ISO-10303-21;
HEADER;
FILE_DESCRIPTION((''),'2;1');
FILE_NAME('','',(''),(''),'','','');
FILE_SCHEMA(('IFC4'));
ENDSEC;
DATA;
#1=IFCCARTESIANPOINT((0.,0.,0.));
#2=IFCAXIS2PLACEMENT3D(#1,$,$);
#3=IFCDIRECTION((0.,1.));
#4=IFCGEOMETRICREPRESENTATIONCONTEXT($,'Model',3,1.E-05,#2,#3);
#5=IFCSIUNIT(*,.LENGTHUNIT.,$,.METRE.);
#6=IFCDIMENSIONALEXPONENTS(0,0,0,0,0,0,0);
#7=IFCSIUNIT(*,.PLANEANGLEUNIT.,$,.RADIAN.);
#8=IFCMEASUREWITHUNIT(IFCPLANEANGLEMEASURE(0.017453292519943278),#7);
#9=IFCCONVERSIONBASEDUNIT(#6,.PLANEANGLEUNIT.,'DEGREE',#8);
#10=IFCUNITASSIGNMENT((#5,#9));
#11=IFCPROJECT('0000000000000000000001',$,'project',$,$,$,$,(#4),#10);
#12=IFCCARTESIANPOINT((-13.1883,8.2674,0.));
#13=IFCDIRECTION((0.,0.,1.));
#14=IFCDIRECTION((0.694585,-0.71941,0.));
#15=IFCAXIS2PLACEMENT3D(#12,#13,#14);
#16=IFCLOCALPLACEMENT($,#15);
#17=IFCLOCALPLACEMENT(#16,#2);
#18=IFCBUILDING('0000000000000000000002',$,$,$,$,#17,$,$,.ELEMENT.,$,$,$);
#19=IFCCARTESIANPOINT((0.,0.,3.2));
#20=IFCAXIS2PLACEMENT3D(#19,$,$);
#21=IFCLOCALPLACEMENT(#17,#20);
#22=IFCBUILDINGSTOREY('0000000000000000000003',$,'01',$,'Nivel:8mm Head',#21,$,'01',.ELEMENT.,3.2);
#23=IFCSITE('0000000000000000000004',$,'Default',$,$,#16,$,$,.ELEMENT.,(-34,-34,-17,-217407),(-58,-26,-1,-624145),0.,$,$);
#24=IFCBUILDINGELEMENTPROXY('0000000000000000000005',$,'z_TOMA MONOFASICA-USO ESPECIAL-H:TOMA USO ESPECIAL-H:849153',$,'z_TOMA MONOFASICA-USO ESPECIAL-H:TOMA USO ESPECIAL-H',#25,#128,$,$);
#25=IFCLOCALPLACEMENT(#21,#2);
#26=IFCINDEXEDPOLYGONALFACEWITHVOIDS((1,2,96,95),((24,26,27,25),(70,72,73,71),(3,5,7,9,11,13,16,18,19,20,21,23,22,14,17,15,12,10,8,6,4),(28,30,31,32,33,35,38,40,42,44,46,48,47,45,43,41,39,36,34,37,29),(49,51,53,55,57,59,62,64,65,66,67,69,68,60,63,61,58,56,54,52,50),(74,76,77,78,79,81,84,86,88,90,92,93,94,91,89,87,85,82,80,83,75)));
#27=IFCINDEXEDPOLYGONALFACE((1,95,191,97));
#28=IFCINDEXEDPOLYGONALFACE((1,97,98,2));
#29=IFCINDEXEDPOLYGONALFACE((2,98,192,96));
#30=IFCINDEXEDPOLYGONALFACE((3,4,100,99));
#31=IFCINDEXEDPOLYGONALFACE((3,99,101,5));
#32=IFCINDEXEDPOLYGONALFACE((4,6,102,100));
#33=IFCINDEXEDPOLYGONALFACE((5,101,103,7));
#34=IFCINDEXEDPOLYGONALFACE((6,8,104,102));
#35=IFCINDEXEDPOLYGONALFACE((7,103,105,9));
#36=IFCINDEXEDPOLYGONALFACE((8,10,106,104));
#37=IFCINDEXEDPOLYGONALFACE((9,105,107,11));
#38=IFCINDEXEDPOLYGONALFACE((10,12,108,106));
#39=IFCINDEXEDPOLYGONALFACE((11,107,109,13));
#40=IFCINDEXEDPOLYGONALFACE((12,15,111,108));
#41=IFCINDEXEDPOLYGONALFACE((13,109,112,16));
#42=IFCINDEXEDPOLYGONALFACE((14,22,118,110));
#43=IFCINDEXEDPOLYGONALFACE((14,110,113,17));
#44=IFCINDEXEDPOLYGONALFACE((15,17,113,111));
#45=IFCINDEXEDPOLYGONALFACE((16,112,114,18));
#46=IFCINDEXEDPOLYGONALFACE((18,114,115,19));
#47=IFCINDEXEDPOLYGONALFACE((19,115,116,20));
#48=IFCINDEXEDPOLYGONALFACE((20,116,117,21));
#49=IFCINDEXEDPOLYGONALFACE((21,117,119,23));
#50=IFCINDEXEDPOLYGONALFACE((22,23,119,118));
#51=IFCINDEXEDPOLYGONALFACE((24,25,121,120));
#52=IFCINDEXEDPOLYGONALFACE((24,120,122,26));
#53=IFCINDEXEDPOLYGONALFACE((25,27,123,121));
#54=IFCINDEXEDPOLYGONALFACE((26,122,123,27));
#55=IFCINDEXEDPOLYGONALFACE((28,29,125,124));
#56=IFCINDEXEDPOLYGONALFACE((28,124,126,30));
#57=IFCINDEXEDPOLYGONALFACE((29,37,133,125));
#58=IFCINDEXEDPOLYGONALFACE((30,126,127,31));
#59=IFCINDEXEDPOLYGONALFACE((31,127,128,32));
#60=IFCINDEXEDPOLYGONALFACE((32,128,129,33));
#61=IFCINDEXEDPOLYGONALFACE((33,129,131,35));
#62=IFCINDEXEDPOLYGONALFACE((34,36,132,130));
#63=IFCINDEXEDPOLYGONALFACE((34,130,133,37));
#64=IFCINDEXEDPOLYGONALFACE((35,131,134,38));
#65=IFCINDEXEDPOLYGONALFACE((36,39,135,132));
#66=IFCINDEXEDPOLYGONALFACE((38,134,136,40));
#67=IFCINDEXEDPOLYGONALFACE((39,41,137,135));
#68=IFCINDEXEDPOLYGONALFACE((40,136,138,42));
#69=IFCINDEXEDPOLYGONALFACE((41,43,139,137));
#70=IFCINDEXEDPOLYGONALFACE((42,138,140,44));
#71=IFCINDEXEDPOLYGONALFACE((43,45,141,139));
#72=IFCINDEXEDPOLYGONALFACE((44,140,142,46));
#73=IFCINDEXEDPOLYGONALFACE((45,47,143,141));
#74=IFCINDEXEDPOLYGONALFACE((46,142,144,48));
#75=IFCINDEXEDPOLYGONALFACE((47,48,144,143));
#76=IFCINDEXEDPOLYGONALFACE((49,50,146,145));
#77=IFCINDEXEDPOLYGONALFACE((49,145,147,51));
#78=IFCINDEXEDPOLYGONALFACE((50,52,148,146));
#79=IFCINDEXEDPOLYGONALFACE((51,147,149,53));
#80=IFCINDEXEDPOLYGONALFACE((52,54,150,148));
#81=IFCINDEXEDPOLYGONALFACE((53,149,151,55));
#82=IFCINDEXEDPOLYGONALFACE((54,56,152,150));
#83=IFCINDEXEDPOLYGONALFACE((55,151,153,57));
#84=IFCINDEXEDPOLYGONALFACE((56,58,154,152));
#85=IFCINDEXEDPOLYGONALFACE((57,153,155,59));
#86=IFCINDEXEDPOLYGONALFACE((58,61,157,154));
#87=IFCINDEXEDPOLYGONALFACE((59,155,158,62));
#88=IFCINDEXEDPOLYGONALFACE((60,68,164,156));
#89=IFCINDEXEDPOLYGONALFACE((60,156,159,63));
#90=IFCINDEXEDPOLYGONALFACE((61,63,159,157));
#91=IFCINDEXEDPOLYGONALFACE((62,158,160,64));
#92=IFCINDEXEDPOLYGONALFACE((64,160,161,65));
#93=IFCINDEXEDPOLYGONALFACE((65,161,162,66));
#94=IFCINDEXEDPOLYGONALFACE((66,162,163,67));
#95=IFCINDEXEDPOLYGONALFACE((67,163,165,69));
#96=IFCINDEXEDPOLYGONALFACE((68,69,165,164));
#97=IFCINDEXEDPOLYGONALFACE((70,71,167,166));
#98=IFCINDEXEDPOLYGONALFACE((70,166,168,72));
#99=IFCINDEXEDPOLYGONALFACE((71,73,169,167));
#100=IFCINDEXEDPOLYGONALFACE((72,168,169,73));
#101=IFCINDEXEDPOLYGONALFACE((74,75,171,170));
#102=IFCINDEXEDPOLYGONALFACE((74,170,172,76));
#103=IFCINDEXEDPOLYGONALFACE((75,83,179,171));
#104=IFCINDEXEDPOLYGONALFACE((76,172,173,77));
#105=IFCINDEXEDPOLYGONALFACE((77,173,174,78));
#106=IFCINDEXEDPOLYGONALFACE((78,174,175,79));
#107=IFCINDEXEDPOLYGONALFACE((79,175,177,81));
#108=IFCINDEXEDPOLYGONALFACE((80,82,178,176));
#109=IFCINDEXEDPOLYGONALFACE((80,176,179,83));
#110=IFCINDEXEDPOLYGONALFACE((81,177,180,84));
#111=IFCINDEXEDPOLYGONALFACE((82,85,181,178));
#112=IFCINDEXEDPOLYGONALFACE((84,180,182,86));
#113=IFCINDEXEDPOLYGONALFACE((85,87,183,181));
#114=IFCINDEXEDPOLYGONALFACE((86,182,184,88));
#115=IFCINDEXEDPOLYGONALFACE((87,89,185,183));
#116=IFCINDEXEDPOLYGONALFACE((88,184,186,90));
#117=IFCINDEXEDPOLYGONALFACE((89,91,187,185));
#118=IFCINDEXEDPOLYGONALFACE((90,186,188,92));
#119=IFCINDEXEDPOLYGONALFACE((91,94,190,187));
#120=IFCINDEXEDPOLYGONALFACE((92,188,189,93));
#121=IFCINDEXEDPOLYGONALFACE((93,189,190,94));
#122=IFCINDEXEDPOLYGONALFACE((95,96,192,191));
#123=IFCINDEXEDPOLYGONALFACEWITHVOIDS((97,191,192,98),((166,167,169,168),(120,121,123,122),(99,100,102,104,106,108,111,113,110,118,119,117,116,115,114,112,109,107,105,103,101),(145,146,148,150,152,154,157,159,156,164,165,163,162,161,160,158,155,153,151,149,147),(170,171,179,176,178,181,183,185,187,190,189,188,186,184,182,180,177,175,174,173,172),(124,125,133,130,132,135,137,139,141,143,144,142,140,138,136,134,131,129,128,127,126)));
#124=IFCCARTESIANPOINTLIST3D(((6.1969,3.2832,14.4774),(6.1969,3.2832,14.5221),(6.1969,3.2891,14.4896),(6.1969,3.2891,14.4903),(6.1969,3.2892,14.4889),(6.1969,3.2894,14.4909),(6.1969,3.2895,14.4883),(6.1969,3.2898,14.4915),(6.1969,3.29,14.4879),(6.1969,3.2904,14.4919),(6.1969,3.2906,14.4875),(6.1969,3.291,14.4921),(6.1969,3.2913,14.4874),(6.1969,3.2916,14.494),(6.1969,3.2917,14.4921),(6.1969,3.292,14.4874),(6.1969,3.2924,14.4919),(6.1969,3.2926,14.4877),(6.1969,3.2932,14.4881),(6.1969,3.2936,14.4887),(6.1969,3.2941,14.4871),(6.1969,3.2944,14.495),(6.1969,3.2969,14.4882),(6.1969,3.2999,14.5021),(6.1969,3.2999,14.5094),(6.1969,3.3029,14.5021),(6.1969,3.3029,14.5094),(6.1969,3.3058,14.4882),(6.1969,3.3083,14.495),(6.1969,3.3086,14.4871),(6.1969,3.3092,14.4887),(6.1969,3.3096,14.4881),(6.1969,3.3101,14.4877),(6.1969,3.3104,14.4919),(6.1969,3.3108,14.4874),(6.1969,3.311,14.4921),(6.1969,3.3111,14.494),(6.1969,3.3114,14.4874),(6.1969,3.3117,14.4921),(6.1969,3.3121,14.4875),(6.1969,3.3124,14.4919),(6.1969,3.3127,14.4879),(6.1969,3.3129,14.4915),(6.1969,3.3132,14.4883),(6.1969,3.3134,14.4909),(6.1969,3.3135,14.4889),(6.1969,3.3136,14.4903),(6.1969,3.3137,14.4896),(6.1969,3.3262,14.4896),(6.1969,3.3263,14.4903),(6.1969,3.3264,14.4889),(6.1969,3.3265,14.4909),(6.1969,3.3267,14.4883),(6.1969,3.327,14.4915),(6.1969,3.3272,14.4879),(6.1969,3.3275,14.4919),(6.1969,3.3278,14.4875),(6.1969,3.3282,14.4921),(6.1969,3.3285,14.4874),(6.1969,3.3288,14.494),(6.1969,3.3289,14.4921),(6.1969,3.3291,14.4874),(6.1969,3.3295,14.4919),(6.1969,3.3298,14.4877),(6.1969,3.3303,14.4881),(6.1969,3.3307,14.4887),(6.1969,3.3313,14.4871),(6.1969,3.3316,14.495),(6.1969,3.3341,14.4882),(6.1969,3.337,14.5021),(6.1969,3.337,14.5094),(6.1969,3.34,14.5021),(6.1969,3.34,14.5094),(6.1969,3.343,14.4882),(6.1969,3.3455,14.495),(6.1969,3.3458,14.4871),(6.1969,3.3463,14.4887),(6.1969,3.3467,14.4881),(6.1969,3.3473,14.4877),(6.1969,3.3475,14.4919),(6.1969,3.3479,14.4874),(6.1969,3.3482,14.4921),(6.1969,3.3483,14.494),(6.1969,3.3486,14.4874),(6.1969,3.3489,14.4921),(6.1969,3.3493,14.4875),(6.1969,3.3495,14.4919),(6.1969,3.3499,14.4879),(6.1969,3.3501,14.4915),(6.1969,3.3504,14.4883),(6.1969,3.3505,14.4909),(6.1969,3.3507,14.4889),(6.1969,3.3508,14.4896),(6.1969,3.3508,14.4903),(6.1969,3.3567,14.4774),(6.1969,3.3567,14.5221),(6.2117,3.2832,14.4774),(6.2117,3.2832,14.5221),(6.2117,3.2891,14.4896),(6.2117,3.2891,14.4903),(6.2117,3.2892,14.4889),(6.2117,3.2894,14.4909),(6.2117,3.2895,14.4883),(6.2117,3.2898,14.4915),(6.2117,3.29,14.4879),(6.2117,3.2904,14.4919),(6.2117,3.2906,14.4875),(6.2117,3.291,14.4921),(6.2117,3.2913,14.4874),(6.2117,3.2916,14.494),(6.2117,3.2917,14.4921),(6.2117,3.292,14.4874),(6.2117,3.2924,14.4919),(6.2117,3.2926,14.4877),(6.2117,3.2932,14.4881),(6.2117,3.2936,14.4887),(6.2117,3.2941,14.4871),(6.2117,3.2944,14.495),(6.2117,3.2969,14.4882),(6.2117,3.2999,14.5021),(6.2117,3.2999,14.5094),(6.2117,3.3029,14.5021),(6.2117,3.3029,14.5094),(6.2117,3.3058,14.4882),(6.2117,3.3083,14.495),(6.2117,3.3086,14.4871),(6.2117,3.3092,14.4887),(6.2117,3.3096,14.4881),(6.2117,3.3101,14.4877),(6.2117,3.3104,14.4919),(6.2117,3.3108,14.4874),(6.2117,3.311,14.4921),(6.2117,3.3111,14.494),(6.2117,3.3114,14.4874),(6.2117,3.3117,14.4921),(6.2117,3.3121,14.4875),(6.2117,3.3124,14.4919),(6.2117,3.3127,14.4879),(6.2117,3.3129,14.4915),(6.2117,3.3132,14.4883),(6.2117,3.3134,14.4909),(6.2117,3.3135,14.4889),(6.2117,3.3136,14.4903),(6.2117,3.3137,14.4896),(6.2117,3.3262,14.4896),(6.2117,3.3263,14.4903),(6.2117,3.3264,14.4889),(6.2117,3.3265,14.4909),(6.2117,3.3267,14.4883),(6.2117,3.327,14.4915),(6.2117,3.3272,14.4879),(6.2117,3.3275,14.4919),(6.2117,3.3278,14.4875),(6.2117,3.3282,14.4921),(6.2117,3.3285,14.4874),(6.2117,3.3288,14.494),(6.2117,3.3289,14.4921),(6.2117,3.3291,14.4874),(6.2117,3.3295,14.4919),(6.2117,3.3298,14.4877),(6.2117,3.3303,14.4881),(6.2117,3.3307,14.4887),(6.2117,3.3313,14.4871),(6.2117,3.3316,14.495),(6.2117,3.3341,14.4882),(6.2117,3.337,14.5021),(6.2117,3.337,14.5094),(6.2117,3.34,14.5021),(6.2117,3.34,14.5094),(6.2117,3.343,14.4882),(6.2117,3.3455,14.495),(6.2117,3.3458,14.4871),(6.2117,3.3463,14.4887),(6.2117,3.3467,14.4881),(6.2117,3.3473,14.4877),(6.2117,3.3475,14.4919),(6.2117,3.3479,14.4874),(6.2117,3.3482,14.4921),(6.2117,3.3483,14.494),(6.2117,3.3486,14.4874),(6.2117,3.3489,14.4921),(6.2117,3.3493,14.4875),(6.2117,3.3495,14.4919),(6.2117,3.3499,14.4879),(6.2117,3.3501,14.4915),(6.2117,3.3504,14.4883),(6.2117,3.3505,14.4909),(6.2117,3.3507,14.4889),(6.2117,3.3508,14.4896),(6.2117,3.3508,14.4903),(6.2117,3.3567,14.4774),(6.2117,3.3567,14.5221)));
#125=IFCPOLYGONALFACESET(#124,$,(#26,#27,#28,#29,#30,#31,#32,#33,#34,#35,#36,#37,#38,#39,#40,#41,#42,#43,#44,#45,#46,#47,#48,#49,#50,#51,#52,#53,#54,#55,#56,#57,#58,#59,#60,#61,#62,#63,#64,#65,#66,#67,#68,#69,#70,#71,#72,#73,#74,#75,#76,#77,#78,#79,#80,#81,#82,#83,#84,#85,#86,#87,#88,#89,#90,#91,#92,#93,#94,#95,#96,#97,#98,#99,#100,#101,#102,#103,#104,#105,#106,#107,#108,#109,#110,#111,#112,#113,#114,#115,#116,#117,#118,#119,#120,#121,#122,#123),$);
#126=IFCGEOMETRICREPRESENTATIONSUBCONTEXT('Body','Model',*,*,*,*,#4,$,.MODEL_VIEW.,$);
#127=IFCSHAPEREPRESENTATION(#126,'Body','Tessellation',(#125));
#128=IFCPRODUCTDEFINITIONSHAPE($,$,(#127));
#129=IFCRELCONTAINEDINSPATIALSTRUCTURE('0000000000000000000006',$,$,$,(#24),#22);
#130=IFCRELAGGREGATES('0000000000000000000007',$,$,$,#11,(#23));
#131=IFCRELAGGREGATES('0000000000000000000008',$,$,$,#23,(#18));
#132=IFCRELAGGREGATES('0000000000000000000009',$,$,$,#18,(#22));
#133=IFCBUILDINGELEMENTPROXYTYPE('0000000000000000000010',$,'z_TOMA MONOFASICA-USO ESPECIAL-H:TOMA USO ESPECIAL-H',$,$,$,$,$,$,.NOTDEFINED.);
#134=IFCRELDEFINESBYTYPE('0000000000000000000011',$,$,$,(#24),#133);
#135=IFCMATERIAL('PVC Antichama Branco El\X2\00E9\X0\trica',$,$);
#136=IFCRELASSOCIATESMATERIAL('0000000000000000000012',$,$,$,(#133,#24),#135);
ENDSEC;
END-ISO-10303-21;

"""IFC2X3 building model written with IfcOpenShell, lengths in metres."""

from ifc_helpers import new_model, entity, si_unit, converted_unit, direction, frame, frame_2d, origin, place, context, subcontext, project, spatial, polyline, circle_curve, parameter, trimmed, segment, composite_curve, outline, extrude, source, transform, mapped, material, type_object, type_shapes, element, save


model = new_model("IFC2X3")

# Units and contexts
model_context = context("Model", 3, precision=1e-05, world=origin(), true_north=direction((0.0, 1.0)))
body_context = subcontext(model_context, "Body", "Model", "MODEL_VIEW")
ifc_project = project(units=[si_unit("LENGTHUNIT", "METRE"), converted_unit("PLANEANGLEUNIT", "DEGREE", entity("IfcPlaneAngleMeasure", 0.017453292519943278), si_unit("PLANEANGLEUNIT", "RADIAN"), dimensions=[0, 0, 0, 0, 0, 0, 0])], contexts=[model_context])

# Site, building, storey
site_placement = place(None, frame((-13.1883, 8.2674, 0.0), z_axis=(0.0, 0.0, 1.0), x_axis=(0.694585, -0.71941, 0.0)))
site = spatial("IfcSite", under=ifc_project, at=site_placement, Name="Default", CompositionType="ELEMENT", RefLatitude=(-34, -34, -17, -217407), RefLongitude=(-58, -26, -1, -624145), RefElevation=0.0)
building_placement = place(site_placement, origin())
building = spatial("IfcBuilding", under=site, at=building_placement, CompositionType="ELEMENT")
storey_placement = place(building_placement, frame((0.0, 0.0, 3.2)))
storey = spatial("IfcBuildingStorey", under=building, at=storey_placement, Name="01", ObjectType="Nivel:8mm Head", LongName="01", CompositionType="ELEMENT", Elevation=3.2)

# Building element proxy
ifc_material_1 = material(Name="PVC Antichama Branco Elétrica")
building_element_proxy_type_1 = type_object("IfcBuildingElementProxyType", Name="z_TOMA MONOFASICA-USO ESPECIAL-H:TOMA USO ESPECIAL-H", PredefinedType="NOTDEFINED", material=ifc_material_1)
shared_shape_1 = source(origin(), body_context, "Body", "SweptSolid", [
    extrude(outline(polyline([(-0.0368, -0.0223), (0.0368, -0.0223), (0.0368, 0.0223), (-0.0368, 0.0223), (-0.0368, -0.0223)]), holes=[composite_curve([segment(polyline([(0.0141, 0.0115), (0.0116, 0.0047)]), True, "CONTINUOUS"), segment(polyline([(0.0116, 0.0047), (0.0088, 0.0057)]), True, "CONTINUOUS"), segment(polyline([(0.0088, 0.0057), (0.0096, 0.0078)]), True, "CONTINUOUS"), segment(trimmed(circle_curve(frame_2d((0.0087, 0.0099), x_axis=(1.0, 0.0)), 0.0024), [parameter(27.118901)], [parameter(292.881099)], True, "PARAMETER"), False, "CONTINUOUS"), segment(polyline([(0.0108, 0.011), (0.0113, 0.0126)]), True, "CONTINUOUS"), segment(polyline([(0.0113, 0.0126), (0.0141, 0.0115)]), True, "CONTINUOUS")], self_intersect=False), composite_curve([segment(polyline([(0.0255, 0.0047), (0.023, 0.0115)]), True, "CONTINUOUS"), segment(polyline([(0.023, 0.0115), (0.0258, 0.0126)]), True, "CONTINUOUS"), segment(polyline([(0.0258, 0.0126), (0.0264, 0.011)]), True, "CONTINUOUS"), segment(trimmed(circle_curve(frame_2d((0.0285, 0.0099), x_axis=(1.0, 0.0)), 0.0024), [parameter(247.118901)], [parameter(152.881099)], True, "PARAMETER"), False, "CONTINUOUS"), segment(polyline([(0.0276, 0.0078), (0.0283, 0.0057)]), True, "CONTINUOUS"), segment(polyline([(0.0283, 0.0057), (0.0255, 0.0047)]), True, "CONTINUOUS")], self_intersect=False), polyline([(0.0201, -0.0024), (0.0201, -0.0097), (0.0171, -0.0097), (0.0171, -0.0024), (0.0201, -0.0024)]), composite_curve([segment(polyline([(-0.0141, 0.0115), (-0.0113, 0.0126)]), True, "CONTINUOUS"), segment(polyline([(-0.0113, 0.0126), (-0.0108, 0.011)]), True, "CONTINUOUS"), segment(trimmed(circle_curve(frame_2d((-0.0087, 0.0099), x_axis=(1.0, 0.0)), 0.0024), [parameter(247.118901)], [parameter(152.881099)], True, "PARAMETER"), False, "CONTINUOUS"), segment(polyline([(-0.0096, 0.0078), (-0.0088, 0.0057)]), True, "CONTINUOUS"), segment(polyline([(-0.0088, 0.0057), (-0.0116, 0.0047)]), True, "CONTINUOUS"), segment(polyline([(-0.0116, 0.0047), (-0.0141, 0.0115)]), True, "CONTINUOUS")], self_intersect=False), composite_curve([segment(polyline([(-0.0255, 0.0047), (-0.0283, 0.0057)]), True, "CONTINUOUS"), segment(polyline([(-0.0283, 0.0057), (-0.0276, 0.0078)]), True, "CONTINUOUS"), segment(trimmed(circle_curve(frame_2d((-0.0285, 0.0099), x_axis=(1.0, 0.0)), 0.0024), [parameter(27.118901)], [parameter(292.881099)], True, "PARAMETER"), False, "CONTINUOUS"), segment(polyline([(-0.0264, 0.011), (-0.0258, 0.0126)]), True, "CONTINUOUS"), segment(polyline([(-0.0258, 0.0126), (-0.023, 0.0115)]), True, "CONTINUOUS"), segment(polyline([(-0.023, 0.0115), (-0.0255, 0.0047)]), True, "CONTINUOUS")], self_intersect=False), polyline([(-0.0201, -0.0024), (-0.0171, -0.0024), (-0.0171, -0.0097), (-0.0201, -0.0097), (-0.0201, -0.0024)])]), frame((0.0, -0.005, 0.0223), z_axis=(0.0, 1.0, 0.0), x_axis=(1.0, 0.0, 0.0)), (0.0, 0.0, 1.0), 0.0148),
])
type_shapes(building_element_proxy_type_1, [shared_shape_1])
for number, where, z_axis, x_axis, name in (
    (1, (6.2019, 3.3199, 14.4774), (0.0, 0.0, 1.0), (0.0, -1.0, 0.0), "z_TOMA MONOFASICA-USO ESPECIAL-H:TOMA USO ESPECIAL-H:849153"),
):
    element("IfcBuildingElementProxy", number, at=place(storey_placement, frame(where, z_axis=z_axis, x_axis=x_axis)), inside=storey, type_object=building_element_proxy_type_1, material=ifc_material_1, Name=name, ObjectType="z_TOMA MONOFASICA-USO ESPECIAL-H:TOMA USO ESPECIAL-H", context=body_context, shape_type="MappedRepresentation", body=[
        mapped(shared_shape_1, transform((0.0, 0.0, 0.0), scale=1.0)),
    ])

save(model, "model.ifc")
